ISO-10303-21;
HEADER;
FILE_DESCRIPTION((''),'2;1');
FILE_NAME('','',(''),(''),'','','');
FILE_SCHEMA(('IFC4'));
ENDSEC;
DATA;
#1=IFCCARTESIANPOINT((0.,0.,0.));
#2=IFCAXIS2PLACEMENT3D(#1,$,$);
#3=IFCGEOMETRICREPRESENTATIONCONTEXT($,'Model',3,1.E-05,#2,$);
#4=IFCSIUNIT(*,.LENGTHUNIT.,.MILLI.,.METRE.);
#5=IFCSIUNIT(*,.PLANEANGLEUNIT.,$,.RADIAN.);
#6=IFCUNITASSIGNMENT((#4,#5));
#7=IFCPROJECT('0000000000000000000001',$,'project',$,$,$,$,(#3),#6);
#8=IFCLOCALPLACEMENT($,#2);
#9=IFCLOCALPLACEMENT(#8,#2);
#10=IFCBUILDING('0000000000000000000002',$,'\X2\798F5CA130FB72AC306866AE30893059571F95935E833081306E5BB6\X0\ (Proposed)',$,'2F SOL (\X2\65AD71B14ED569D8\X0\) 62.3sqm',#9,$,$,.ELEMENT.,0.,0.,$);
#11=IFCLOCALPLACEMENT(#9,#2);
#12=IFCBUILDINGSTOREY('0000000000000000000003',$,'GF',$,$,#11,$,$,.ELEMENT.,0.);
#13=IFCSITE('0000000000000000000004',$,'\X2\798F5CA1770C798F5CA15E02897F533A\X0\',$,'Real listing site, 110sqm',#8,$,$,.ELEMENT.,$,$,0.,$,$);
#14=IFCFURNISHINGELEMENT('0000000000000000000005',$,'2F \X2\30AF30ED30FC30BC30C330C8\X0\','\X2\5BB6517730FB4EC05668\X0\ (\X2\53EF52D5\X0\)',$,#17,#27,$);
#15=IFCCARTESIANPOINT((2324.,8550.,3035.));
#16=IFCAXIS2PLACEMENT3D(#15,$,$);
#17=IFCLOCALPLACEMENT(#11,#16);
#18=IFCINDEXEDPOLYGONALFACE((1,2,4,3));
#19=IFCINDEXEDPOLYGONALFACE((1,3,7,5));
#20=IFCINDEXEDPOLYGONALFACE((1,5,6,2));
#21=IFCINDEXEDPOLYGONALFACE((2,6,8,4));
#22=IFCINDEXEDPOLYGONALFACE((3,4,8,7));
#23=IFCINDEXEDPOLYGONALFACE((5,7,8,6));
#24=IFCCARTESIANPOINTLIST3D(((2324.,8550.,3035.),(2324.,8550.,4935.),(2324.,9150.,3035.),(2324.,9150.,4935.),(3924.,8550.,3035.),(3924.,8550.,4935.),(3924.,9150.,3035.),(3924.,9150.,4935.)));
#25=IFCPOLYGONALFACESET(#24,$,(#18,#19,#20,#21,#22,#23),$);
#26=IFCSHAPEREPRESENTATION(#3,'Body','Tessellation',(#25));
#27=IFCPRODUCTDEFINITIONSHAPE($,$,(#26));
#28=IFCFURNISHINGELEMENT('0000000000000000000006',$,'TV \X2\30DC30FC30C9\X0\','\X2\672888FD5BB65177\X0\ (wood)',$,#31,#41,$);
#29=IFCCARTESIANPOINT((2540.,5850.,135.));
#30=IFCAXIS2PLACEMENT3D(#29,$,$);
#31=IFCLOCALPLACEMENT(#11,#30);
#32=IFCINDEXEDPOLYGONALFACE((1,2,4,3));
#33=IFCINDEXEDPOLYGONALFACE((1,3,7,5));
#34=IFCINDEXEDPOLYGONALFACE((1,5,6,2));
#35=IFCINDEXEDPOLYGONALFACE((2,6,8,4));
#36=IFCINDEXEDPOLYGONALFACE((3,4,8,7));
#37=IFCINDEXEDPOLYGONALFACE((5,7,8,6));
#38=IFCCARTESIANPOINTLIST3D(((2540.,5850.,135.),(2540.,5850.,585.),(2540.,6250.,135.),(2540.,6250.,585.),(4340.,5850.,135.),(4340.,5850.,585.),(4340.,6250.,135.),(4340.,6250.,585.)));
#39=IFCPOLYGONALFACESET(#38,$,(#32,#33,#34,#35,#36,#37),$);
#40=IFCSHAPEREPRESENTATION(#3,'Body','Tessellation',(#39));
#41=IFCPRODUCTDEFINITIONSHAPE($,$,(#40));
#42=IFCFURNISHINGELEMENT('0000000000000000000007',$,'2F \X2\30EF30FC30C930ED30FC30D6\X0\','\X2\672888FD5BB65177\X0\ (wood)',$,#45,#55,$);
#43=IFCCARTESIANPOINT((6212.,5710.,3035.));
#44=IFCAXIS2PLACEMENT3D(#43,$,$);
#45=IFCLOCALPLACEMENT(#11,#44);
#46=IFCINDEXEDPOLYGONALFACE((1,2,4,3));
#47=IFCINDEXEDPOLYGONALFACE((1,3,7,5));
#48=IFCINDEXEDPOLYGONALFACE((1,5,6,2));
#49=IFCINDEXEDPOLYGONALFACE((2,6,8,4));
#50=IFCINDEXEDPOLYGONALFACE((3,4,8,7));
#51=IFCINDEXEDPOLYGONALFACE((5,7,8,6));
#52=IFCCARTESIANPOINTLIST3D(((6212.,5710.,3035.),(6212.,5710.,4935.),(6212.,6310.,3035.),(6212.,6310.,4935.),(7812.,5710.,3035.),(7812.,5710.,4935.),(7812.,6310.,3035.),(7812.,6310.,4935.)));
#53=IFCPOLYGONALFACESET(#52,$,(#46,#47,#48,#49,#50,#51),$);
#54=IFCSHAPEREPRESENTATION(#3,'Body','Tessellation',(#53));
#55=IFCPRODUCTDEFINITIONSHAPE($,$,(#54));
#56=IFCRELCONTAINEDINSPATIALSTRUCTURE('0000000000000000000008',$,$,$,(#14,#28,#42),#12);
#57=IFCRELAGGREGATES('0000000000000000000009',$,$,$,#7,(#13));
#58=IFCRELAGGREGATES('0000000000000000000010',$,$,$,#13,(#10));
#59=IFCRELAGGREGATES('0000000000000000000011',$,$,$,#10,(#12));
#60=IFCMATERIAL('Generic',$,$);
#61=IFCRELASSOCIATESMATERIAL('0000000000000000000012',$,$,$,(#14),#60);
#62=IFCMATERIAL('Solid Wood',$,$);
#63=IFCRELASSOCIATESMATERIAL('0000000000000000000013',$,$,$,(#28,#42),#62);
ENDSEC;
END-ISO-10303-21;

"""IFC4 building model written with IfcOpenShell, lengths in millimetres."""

from ifc_helpers import new_model, si_unit, frame, frame_2d, origin, place, context, project, spatial, rectangle, extrude, material, element, save


model = new_model("IFC4")

# Units and contexts
model_context = context("Model", 3, precision=1e-05, world=origin())
ifc_project = project(units=[si_unit("LENGTHUNIT", "METRE", prefix="MILLI"), si_unit("PLANEANGLEUNIT", "RADIAN")], contexts=[model_context])

# Site, building, storey
site_placement = place(None, origin())
site = spatial("IfcSite", under=ifc_project, at=site_placement, Name="福岡県福岡市西区", ObjectType="Real listing site, 110sqm", CompositionType="ELEMENT", RefElevation=0.0)
building_placement = place(site_placement, origin())
building = spatial("IfcBuilding", under=site, at=building_placement, Name="福岡・犬と暮らす土間広めの家 (Proposed)", ObjectType="2F SOL (断熱仕様) 62.3sqm", CompositionType="ELEMENT", ElevationOfRefHeight=0.0, ElevationOfTerrain=0.0)
storey_placement = place(building_placement, origin())
storey = spatial("IfcBuildingStorey", under=building, at=storey_placement, Name="GF", CompositionType="ELEMENT", Elevation=0.0)

# Shared definitions
ifc_material_1 = material(Name="Solid Wood")

# Shared definitions
ifc_material_2 = material(Name="Generic")

# Furnishing elements
furnishing_1_placement = place(storey_placement, frame((2324.0, 8550.0, 3035.0)))
element("IfcFurnishingElement", 1, at=furnishing_1_placement, inside=storey, material=ifc_material_2, Name="2F クローゼット", Description="家具・什器 (可動)", context=model_context, shape_type="SweptSolid", body=[
    extrude(rectangle(XDim=1600.0, YDim=600.0, at=frame_2d((800.0, 300.0))), frame((2324.0, 8550.0, 3035.0)), (0.0, 0.0, 1.0), 1900.0),
])
furnishing_2_placement = place(storey_placement, frame((2540.0, 5850.0, 135.0)))
element("IfcFurnishingElement", 2, at=furnishing_2_placement, inside=storey, material=ifc_material_1, Name="TV ボード", Description="木製家具 (wood)", context=model_context, shape_type="SweptSolid", body=[
    extrude(rectangle(XDim=1800.0, YDim=400.0, at=frame_2d((900.0, 200.0))), frame((2540.0, 5850.0, 135.0)), (0.0, 0.0, 1.0), 450.0),
])
furnishing_3_placement = place(storey_placement, frame((6212.0, 5710.0, 3035.0)))
element("IfcFurnishingElement", 3, at=furnishing_3_placement, inside=storey, material=ifc_material_1, Name="2F ワードローブ", Description="木製家具 (wood)", context=model_context, shape_type="SweptSolid", body=[
    extrude(rectangle(XDim=1600.0, YDim=600.0, at=frame_2d((800.0, 300.0))), frame((6212.0, 5710.0, 3035.0)), (0.0, 0.0, 1.0), 1900.0),
])

save(model, "model.ifc")
